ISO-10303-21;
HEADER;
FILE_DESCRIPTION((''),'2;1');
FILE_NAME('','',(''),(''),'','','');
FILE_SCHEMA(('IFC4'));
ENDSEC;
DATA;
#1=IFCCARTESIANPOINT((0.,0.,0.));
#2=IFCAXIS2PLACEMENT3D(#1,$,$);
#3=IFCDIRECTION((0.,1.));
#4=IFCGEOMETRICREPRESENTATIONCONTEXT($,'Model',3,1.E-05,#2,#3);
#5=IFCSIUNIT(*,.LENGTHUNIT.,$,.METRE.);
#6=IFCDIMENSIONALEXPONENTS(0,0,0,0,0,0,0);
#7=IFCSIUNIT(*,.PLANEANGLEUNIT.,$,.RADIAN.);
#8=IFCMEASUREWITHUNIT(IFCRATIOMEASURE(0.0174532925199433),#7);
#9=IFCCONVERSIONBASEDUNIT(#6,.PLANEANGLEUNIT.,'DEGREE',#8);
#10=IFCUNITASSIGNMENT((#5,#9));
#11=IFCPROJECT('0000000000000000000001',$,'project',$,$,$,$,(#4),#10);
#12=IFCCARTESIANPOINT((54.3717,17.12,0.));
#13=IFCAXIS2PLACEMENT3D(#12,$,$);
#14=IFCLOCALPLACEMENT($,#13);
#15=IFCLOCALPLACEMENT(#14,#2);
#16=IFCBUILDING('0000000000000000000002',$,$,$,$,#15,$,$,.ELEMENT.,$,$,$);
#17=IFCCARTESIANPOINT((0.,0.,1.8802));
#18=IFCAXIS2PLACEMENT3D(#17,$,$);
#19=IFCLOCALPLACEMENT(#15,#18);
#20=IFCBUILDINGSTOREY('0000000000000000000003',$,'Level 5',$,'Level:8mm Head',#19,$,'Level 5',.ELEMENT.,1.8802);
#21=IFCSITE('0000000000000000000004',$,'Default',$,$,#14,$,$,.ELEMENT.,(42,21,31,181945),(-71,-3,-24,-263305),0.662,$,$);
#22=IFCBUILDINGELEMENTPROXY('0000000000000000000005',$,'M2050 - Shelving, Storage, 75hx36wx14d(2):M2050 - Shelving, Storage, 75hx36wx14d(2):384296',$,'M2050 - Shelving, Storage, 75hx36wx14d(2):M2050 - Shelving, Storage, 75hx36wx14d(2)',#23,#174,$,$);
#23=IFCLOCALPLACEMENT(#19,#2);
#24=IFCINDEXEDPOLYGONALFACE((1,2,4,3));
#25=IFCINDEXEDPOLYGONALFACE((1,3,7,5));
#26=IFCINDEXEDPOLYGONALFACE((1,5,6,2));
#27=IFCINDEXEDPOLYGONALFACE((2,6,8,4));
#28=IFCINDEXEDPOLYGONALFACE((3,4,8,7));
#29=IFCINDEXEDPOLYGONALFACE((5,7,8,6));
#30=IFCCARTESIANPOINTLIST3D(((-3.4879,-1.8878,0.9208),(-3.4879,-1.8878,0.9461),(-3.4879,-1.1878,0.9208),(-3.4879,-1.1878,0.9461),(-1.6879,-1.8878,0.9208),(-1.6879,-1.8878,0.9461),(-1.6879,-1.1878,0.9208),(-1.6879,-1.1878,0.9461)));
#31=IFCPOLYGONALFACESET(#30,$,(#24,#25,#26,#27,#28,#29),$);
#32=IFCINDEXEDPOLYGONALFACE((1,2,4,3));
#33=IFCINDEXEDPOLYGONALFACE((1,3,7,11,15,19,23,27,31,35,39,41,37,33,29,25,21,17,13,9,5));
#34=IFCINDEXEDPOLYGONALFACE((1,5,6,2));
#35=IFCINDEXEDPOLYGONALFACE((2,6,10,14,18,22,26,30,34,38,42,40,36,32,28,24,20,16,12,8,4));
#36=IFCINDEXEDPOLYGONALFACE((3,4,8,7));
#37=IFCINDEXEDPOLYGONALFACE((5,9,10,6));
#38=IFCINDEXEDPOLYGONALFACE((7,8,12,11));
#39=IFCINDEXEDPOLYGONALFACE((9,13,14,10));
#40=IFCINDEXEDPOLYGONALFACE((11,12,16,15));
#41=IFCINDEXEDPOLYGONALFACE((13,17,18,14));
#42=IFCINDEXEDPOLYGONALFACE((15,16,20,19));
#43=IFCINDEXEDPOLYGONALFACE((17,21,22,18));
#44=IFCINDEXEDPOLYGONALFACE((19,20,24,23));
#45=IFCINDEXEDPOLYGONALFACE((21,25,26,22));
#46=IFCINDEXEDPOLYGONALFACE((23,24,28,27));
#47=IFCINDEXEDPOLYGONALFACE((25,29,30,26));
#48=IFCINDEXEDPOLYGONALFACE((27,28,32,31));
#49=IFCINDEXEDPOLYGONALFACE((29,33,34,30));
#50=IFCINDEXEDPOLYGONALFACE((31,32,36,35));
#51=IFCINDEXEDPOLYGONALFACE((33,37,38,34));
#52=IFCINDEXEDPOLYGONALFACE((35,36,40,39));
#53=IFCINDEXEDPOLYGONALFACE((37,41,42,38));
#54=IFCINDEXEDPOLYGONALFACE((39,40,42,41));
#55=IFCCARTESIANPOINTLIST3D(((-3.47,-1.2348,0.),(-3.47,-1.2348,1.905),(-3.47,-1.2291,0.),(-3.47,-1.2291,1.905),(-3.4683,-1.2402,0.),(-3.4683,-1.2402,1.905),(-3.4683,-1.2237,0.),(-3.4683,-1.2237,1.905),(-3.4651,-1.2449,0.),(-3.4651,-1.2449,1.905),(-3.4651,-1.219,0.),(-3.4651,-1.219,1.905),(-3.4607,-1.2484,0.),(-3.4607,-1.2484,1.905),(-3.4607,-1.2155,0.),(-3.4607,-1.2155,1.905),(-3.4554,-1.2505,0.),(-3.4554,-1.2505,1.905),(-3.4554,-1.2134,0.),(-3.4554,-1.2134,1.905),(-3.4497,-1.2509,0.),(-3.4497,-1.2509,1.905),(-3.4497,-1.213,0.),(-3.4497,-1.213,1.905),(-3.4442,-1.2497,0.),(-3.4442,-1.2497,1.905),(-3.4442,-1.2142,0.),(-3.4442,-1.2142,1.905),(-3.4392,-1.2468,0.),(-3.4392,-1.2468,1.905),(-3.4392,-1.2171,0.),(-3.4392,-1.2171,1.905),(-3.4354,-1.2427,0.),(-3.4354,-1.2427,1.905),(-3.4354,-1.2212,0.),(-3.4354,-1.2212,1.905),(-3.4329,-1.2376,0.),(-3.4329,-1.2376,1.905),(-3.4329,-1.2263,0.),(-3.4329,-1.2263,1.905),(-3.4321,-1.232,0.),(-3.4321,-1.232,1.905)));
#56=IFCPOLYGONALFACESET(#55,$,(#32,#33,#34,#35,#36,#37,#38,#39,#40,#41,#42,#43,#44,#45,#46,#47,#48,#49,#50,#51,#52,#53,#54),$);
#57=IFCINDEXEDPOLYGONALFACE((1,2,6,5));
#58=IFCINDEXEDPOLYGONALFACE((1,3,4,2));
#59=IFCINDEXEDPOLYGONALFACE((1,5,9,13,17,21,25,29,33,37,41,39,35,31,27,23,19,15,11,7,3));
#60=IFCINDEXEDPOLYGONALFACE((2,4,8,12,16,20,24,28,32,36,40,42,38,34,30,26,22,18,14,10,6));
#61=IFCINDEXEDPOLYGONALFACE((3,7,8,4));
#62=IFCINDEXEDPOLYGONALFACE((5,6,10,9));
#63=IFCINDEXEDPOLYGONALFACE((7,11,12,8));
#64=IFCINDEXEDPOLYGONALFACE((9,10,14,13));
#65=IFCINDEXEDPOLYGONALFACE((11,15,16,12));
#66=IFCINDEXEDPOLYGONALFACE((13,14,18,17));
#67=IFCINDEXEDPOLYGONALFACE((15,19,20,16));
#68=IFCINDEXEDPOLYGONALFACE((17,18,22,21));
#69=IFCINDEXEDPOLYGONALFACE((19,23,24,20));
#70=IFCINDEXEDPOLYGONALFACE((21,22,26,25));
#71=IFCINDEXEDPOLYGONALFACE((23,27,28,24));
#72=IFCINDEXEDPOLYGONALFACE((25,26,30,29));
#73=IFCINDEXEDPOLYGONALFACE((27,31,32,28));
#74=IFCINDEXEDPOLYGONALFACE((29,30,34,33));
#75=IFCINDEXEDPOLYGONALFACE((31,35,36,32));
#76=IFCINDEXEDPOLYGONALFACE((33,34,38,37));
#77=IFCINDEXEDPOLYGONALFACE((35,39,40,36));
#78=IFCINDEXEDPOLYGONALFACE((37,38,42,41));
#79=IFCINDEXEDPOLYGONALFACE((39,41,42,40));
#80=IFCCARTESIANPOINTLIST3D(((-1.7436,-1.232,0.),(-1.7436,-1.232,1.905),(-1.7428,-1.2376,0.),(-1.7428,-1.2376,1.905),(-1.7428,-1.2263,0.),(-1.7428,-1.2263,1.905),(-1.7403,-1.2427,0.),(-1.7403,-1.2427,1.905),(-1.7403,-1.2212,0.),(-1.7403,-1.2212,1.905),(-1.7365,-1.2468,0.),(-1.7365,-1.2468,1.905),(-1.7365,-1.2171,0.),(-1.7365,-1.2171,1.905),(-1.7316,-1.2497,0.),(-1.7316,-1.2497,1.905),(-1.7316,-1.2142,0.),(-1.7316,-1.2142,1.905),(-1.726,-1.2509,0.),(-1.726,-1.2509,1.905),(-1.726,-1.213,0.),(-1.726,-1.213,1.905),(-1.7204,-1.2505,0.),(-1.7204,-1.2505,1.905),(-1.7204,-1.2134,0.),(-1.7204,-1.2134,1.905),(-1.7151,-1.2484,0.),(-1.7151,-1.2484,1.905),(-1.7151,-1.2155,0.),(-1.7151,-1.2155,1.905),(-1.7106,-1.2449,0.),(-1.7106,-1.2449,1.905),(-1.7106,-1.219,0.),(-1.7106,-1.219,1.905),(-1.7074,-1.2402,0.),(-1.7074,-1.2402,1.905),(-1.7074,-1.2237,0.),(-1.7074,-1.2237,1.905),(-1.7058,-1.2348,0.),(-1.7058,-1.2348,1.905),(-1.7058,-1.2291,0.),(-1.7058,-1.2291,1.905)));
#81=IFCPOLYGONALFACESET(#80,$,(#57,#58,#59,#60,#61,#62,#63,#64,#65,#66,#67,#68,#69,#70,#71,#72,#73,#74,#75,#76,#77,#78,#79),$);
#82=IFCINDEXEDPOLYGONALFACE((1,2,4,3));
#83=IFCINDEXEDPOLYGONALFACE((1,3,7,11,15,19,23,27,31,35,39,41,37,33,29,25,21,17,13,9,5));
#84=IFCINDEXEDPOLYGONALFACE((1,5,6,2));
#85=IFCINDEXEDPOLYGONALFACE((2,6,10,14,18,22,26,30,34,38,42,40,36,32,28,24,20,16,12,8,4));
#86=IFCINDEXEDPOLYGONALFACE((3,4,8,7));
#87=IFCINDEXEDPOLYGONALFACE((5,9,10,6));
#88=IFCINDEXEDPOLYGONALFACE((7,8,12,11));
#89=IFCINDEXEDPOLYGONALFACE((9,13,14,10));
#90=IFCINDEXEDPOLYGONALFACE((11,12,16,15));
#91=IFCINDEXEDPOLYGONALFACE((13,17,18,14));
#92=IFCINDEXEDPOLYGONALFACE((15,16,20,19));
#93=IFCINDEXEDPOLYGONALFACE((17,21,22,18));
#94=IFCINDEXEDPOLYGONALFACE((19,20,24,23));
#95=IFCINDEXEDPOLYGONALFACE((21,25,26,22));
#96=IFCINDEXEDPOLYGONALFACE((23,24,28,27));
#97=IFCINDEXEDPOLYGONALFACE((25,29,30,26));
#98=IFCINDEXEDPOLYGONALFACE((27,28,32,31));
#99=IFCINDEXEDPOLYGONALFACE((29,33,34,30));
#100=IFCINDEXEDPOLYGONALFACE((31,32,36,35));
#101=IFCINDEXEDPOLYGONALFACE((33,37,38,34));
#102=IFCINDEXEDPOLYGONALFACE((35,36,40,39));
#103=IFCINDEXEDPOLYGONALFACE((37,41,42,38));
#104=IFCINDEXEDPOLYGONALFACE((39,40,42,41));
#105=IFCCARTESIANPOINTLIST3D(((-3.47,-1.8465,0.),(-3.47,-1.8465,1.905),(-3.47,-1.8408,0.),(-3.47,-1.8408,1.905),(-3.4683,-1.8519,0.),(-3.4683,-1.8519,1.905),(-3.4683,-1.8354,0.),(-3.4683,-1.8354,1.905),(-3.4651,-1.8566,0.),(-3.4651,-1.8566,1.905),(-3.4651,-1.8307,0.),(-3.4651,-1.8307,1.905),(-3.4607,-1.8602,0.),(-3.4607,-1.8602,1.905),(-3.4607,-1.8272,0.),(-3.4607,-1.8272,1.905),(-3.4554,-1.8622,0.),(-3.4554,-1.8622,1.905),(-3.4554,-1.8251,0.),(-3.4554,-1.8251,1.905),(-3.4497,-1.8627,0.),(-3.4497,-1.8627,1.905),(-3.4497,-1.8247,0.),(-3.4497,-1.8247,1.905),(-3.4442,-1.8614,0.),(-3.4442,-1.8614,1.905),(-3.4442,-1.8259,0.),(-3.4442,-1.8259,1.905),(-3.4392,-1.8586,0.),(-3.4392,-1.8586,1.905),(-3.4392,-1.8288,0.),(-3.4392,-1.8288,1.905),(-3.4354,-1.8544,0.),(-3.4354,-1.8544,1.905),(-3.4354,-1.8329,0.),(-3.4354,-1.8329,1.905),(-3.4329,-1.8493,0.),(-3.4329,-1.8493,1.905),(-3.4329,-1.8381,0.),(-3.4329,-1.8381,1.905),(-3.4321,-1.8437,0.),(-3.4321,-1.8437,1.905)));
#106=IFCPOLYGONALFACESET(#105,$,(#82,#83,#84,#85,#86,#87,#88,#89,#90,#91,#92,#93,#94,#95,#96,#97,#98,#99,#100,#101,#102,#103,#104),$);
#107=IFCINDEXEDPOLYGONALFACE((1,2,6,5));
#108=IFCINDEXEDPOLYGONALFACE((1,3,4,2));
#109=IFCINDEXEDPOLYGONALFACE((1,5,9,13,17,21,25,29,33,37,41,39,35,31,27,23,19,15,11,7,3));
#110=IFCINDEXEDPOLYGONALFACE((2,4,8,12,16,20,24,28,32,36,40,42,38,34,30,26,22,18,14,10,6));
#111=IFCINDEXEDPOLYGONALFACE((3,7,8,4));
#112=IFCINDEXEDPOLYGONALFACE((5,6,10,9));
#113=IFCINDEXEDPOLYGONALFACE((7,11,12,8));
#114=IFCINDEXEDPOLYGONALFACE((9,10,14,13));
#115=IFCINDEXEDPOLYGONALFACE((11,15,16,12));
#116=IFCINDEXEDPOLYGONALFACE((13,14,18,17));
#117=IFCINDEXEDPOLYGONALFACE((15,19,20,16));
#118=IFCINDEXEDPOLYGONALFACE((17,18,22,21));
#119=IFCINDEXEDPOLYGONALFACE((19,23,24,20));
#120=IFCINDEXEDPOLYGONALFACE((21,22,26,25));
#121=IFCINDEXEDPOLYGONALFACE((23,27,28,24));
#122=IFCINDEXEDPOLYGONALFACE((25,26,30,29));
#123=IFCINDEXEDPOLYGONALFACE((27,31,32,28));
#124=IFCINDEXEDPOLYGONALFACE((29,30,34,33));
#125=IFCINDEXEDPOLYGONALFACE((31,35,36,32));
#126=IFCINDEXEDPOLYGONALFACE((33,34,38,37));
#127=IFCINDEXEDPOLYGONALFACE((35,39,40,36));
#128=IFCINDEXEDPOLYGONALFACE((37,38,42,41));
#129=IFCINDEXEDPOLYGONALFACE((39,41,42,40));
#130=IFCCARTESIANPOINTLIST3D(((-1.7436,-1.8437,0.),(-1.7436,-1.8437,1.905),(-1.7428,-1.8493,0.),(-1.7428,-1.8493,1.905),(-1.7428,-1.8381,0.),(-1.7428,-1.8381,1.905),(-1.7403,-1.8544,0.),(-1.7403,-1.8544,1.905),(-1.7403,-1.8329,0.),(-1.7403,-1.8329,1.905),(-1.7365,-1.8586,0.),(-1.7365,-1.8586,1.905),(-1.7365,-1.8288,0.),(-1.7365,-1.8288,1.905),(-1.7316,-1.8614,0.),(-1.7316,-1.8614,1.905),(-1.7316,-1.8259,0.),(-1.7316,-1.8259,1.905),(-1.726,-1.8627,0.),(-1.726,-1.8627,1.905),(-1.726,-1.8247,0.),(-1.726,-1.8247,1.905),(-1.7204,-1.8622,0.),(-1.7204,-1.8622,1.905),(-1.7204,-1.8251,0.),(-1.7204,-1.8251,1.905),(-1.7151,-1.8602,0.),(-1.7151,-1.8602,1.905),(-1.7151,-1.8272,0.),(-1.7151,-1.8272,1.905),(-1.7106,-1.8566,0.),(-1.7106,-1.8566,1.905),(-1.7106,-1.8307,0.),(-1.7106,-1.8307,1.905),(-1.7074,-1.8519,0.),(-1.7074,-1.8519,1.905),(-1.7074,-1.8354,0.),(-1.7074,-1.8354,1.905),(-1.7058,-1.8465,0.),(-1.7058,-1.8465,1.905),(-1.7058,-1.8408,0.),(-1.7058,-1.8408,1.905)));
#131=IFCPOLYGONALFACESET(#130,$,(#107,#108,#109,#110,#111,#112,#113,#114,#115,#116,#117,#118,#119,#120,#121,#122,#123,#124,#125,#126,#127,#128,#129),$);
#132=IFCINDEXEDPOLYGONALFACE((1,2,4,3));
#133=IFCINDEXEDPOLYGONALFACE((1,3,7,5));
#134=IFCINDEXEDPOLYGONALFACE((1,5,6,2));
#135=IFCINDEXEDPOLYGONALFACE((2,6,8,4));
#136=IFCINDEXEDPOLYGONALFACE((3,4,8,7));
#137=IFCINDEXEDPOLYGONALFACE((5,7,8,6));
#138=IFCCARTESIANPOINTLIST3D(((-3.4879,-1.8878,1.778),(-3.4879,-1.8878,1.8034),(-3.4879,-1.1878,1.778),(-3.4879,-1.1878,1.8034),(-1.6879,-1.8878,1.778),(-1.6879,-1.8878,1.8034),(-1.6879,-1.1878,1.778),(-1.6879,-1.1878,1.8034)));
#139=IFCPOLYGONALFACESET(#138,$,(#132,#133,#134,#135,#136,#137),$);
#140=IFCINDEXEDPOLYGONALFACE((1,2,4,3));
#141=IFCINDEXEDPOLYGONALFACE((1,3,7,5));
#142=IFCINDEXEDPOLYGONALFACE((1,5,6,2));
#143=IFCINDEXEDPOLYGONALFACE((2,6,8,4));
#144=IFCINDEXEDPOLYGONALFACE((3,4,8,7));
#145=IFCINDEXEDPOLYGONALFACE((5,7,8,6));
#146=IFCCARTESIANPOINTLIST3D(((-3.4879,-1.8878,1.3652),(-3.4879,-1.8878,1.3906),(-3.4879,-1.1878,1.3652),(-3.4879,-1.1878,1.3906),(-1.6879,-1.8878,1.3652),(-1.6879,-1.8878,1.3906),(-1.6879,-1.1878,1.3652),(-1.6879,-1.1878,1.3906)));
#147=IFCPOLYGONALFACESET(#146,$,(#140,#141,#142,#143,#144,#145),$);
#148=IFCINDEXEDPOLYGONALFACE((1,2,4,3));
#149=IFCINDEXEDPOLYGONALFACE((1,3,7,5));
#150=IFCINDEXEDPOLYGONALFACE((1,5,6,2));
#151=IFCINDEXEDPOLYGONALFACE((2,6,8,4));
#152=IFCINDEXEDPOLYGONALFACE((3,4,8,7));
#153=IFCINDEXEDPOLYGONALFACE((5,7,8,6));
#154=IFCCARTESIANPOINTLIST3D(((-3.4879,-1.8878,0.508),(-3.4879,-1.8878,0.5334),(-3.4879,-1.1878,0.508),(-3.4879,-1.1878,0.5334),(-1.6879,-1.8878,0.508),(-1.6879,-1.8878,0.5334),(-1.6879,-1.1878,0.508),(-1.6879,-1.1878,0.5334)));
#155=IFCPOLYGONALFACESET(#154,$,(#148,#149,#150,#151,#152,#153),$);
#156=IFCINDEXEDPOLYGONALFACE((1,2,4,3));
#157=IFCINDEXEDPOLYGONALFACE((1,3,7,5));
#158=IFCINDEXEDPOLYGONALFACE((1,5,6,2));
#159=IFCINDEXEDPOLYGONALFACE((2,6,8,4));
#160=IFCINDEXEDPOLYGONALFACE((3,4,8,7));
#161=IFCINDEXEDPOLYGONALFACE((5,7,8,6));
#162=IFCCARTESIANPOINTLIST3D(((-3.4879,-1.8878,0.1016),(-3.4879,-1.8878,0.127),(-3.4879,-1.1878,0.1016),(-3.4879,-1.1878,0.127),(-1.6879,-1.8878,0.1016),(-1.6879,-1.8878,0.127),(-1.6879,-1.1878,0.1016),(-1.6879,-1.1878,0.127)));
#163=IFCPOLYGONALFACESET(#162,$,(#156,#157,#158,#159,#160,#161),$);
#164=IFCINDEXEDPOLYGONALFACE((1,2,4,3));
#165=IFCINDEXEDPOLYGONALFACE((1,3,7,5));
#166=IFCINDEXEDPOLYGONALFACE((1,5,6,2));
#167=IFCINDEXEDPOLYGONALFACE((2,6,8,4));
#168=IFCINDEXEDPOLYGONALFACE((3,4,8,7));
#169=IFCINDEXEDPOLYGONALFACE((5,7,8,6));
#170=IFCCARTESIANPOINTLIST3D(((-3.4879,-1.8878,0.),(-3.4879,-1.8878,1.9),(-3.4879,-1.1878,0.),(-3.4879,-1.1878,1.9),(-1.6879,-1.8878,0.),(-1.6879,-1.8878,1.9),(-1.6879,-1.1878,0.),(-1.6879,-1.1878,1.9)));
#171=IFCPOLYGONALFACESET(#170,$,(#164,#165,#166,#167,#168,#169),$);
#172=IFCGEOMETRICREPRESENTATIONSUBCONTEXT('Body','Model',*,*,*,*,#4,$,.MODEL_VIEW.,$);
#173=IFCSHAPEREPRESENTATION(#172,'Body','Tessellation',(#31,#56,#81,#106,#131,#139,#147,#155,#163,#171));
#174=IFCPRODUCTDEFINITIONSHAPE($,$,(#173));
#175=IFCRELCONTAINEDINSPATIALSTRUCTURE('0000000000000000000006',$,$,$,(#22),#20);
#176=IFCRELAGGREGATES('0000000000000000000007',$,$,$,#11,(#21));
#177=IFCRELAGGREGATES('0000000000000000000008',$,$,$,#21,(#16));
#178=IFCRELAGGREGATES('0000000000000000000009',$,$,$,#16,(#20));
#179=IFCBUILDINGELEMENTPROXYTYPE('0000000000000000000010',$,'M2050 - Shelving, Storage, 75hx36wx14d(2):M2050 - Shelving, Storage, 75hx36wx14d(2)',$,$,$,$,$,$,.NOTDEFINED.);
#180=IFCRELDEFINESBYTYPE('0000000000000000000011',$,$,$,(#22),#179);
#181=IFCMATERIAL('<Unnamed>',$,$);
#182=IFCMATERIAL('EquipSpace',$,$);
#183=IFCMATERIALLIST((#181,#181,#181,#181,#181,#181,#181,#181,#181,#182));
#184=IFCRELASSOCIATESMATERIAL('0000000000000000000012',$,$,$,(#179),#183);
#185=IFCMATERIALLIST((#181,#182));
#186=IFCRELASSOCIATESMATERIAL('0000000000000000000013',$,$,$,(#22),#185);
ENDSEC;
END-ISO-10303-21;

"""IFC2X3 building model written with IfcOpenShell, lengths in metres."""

from ifc_helpers import new_model, entity, si_unit, converted_unit, direction, frame, frame_2d, origin, origin_2d_with_axis, place, context, subcontext, project, spatial, rectangle, circle, extrude, source, transform, mapped, material, material_list, type_object, type_shapes, element, save


model = new_model("IFC2X3")

# Units and contexts
model_context = context("Model", 3, precision=1e-05, world=origin(), true_north=direction((0.0, 1.0)))
body_context = subcontext(model_context, "Body", "Model", "MODEL_VIEW")
ifc_project = project(units=[si_unit("LENGTHUNIT", "METRE"), converted_unit("PLANEANGLEUNIT", "DEGREE", entity("IfcRatioMeasure", 0.0174532925199433), si_unit("PLANEANGLEUNIT", "RADIAN"), dimensions=[0, 0, 0, 0, 0, 0, 0])], contexts=[model_context])

# Site, building, storey
site_placement = place(None, frame((54.3717, 17.12, 0.0)))
site = spatial("IfcSite", under=ifc_project, at=site_placement, Name="Default", CompositionType="ELEMENT", RefLatitude=(42, 21, 31, 181945), RefLongitude=(-71, -3, -24, -263305), RefElevation=0.662)
building_placement = place(site_placement, origin())
building = spatial("IfcBuilding", under=site, at=building_placement, CompositionType="ELEMENT")
storey_placement = place(building_placement, frame((0.0, 0.0, 1.8802)))
storey = spatial("IfcBuildingStorey", under=building, at=storey_placement, Name="Level 5", ObjectType="Level:8mm Head", LongName="Level 5", CompositionType="ELEMENT", Elevation=1.8802)

# Building element proxy
ifc_material_1 = material(Name="<Unnamed>")
ifc_material_2 = material(Name="EquipSpace")
ifc_material_list_1 = material_list([ifc_material_1, ifc_material_1, ifc_material_1, ifc_material_1, ifc_material_1, ifc_material_1, ifc_material_1, ifc_material_1, ifc_material_1, ifc_material_2])
building_element_proxy_type = type_object("IfcBuildingElementProxyType", Name="M2050 - Shelving, Storage, 75hx36wx14d(2):M2050 - Shelving, Storage, 75hx36wx14d(2)", PredefinedType="NOTDEFINED", material=ifc_material_list_1)
shared_shape = source(origin(), body_context, "Body", "SweptSolid", [
    extrude(rectangle(XDim=1.8, YDim=0.7, at=origin_2d_with_axis()), frame((0.0, 0.0, 0.9207), z_axis=(0.0, 0.0, 1.0), x_axis=(-1.0, 0.0, 0.0)), (0.0, 0.0, 1.0), 0.0254),
    extrude(circle(Radius=0.0191, at=origin_2d_with_axis()), frame((0.8633, -0.3059, 0.0), z_axis=(0.0, 0.0, 1.0), x_axis=(-1.0, 0.0, 0.0)), (0.0, 0.0, 1.0), 1.905),
    extrude(circle(Radius=0.0191, at=origin_2d_with_axis()), frame((-0.8633, -0.3059, 0.0)), (0.0, 0.0, 1.0), 1.905),
    extrude(circle(Radius=0.0191, at=origin_2d_with_axis()), frame((0.8633, 0.3059, 0.0), z_axis=(0.0, 0.0, 1.0), x_axis=(-1.0, 0.0, 0.0)), (0.0, 0.0, 1.0), 1.905),
    extrude(circle(Radius=0.0191, at=origin_2d_with_axis()), frame((-0.8633, 0.3059, 0.0)), (0.0, 0.0, 1.0), 1.905),
    extrude(rectangle(XDim=1.8, YDim=0.7, at=origin_2d_with_axis()), frame((0.0, 0.0, 1.778), z_axis=(0.0, 0.0, 1.0), x_axis=(-1.0, 0.0, 0.0)), (0.0, 0.0, 1.0), 0.0254),
    extrude(rectangle(XDim=1.8, YDim=0.7, at=origin_2d_with_axis()), frame((0.0, 0.0, 1.3653), z_axis=(0.0, 0.0, 1.0), x_axis=(-1.0, 0.0, 0.0)), (0.0, 0.0, 1.0), 0.0254),
    extrude(rectangle(XDim=1.8, YDim=0.7, at=origin_2d_with_axis()), frame((0.0, 0.0, 0.508), z_axis=(0.0, 0.0, 1.0), x_axis=(-1.0, 0.0, 0.0)), (0.0, 0.0, 1.0), 0.0254),
    extrude(rectangle(XDim=1.8, YDim=0.7, at=origin_2d_with_axis()), frame((0.0, 0.0, 0.1016), z_axis=(0.0, 0.0, 1.0), x_axis=(-1.0, 0.0, 0.0)), (0.0, 0.0, 1.0), 0.0254),
    extrude(rectangle(XDim=0.7, YDim=1.8, at=frame_2d((0.0, 0.18), x_axis=(1.0, 0.0))), frame((-0.18, 0.0, 0.0), z_axis=(0.0, 0.0, 1.0), x_axis=(0.0, -1.0, 0.0)), (0.0, 0.0, 1.0), 1.9),
])
type_shapes(building_element_proxy_type, [shared_shape])
ifc_material_list_2 = material_list([ifc_material_1, ifc_material_2])
proxy_1_placement = place(storey_placement, frame((-2.5879, -1.5378, 0.0), z_axis=(0.0, 0.0, 1.0), x_axis=(-1.0, 0.0, 0.0)))
element("IfcBuildingElementProxy", 1, at=proxy_1_placement, inside=storey, type_object=building_element_proxy_type, material=ifc_material_list_2, Name="M2050 - Shelving, Storage, 75hx36wx14d(2):M2050 - Shelving, Storage, 75hx36wx14d(2):384296", ObjectType="M2050 - Shelving, Storage, 75hx36wx14d(2):M2050 - Shelving, Storage, 75hx36wx14d(2)", context=body_context, shape_type="MappedRepresentation", body=[
    mapped(shared_shape, transform((0.0, 0.0, 0.0), scale=1.0)),
])

save(model, "model.ifc")
